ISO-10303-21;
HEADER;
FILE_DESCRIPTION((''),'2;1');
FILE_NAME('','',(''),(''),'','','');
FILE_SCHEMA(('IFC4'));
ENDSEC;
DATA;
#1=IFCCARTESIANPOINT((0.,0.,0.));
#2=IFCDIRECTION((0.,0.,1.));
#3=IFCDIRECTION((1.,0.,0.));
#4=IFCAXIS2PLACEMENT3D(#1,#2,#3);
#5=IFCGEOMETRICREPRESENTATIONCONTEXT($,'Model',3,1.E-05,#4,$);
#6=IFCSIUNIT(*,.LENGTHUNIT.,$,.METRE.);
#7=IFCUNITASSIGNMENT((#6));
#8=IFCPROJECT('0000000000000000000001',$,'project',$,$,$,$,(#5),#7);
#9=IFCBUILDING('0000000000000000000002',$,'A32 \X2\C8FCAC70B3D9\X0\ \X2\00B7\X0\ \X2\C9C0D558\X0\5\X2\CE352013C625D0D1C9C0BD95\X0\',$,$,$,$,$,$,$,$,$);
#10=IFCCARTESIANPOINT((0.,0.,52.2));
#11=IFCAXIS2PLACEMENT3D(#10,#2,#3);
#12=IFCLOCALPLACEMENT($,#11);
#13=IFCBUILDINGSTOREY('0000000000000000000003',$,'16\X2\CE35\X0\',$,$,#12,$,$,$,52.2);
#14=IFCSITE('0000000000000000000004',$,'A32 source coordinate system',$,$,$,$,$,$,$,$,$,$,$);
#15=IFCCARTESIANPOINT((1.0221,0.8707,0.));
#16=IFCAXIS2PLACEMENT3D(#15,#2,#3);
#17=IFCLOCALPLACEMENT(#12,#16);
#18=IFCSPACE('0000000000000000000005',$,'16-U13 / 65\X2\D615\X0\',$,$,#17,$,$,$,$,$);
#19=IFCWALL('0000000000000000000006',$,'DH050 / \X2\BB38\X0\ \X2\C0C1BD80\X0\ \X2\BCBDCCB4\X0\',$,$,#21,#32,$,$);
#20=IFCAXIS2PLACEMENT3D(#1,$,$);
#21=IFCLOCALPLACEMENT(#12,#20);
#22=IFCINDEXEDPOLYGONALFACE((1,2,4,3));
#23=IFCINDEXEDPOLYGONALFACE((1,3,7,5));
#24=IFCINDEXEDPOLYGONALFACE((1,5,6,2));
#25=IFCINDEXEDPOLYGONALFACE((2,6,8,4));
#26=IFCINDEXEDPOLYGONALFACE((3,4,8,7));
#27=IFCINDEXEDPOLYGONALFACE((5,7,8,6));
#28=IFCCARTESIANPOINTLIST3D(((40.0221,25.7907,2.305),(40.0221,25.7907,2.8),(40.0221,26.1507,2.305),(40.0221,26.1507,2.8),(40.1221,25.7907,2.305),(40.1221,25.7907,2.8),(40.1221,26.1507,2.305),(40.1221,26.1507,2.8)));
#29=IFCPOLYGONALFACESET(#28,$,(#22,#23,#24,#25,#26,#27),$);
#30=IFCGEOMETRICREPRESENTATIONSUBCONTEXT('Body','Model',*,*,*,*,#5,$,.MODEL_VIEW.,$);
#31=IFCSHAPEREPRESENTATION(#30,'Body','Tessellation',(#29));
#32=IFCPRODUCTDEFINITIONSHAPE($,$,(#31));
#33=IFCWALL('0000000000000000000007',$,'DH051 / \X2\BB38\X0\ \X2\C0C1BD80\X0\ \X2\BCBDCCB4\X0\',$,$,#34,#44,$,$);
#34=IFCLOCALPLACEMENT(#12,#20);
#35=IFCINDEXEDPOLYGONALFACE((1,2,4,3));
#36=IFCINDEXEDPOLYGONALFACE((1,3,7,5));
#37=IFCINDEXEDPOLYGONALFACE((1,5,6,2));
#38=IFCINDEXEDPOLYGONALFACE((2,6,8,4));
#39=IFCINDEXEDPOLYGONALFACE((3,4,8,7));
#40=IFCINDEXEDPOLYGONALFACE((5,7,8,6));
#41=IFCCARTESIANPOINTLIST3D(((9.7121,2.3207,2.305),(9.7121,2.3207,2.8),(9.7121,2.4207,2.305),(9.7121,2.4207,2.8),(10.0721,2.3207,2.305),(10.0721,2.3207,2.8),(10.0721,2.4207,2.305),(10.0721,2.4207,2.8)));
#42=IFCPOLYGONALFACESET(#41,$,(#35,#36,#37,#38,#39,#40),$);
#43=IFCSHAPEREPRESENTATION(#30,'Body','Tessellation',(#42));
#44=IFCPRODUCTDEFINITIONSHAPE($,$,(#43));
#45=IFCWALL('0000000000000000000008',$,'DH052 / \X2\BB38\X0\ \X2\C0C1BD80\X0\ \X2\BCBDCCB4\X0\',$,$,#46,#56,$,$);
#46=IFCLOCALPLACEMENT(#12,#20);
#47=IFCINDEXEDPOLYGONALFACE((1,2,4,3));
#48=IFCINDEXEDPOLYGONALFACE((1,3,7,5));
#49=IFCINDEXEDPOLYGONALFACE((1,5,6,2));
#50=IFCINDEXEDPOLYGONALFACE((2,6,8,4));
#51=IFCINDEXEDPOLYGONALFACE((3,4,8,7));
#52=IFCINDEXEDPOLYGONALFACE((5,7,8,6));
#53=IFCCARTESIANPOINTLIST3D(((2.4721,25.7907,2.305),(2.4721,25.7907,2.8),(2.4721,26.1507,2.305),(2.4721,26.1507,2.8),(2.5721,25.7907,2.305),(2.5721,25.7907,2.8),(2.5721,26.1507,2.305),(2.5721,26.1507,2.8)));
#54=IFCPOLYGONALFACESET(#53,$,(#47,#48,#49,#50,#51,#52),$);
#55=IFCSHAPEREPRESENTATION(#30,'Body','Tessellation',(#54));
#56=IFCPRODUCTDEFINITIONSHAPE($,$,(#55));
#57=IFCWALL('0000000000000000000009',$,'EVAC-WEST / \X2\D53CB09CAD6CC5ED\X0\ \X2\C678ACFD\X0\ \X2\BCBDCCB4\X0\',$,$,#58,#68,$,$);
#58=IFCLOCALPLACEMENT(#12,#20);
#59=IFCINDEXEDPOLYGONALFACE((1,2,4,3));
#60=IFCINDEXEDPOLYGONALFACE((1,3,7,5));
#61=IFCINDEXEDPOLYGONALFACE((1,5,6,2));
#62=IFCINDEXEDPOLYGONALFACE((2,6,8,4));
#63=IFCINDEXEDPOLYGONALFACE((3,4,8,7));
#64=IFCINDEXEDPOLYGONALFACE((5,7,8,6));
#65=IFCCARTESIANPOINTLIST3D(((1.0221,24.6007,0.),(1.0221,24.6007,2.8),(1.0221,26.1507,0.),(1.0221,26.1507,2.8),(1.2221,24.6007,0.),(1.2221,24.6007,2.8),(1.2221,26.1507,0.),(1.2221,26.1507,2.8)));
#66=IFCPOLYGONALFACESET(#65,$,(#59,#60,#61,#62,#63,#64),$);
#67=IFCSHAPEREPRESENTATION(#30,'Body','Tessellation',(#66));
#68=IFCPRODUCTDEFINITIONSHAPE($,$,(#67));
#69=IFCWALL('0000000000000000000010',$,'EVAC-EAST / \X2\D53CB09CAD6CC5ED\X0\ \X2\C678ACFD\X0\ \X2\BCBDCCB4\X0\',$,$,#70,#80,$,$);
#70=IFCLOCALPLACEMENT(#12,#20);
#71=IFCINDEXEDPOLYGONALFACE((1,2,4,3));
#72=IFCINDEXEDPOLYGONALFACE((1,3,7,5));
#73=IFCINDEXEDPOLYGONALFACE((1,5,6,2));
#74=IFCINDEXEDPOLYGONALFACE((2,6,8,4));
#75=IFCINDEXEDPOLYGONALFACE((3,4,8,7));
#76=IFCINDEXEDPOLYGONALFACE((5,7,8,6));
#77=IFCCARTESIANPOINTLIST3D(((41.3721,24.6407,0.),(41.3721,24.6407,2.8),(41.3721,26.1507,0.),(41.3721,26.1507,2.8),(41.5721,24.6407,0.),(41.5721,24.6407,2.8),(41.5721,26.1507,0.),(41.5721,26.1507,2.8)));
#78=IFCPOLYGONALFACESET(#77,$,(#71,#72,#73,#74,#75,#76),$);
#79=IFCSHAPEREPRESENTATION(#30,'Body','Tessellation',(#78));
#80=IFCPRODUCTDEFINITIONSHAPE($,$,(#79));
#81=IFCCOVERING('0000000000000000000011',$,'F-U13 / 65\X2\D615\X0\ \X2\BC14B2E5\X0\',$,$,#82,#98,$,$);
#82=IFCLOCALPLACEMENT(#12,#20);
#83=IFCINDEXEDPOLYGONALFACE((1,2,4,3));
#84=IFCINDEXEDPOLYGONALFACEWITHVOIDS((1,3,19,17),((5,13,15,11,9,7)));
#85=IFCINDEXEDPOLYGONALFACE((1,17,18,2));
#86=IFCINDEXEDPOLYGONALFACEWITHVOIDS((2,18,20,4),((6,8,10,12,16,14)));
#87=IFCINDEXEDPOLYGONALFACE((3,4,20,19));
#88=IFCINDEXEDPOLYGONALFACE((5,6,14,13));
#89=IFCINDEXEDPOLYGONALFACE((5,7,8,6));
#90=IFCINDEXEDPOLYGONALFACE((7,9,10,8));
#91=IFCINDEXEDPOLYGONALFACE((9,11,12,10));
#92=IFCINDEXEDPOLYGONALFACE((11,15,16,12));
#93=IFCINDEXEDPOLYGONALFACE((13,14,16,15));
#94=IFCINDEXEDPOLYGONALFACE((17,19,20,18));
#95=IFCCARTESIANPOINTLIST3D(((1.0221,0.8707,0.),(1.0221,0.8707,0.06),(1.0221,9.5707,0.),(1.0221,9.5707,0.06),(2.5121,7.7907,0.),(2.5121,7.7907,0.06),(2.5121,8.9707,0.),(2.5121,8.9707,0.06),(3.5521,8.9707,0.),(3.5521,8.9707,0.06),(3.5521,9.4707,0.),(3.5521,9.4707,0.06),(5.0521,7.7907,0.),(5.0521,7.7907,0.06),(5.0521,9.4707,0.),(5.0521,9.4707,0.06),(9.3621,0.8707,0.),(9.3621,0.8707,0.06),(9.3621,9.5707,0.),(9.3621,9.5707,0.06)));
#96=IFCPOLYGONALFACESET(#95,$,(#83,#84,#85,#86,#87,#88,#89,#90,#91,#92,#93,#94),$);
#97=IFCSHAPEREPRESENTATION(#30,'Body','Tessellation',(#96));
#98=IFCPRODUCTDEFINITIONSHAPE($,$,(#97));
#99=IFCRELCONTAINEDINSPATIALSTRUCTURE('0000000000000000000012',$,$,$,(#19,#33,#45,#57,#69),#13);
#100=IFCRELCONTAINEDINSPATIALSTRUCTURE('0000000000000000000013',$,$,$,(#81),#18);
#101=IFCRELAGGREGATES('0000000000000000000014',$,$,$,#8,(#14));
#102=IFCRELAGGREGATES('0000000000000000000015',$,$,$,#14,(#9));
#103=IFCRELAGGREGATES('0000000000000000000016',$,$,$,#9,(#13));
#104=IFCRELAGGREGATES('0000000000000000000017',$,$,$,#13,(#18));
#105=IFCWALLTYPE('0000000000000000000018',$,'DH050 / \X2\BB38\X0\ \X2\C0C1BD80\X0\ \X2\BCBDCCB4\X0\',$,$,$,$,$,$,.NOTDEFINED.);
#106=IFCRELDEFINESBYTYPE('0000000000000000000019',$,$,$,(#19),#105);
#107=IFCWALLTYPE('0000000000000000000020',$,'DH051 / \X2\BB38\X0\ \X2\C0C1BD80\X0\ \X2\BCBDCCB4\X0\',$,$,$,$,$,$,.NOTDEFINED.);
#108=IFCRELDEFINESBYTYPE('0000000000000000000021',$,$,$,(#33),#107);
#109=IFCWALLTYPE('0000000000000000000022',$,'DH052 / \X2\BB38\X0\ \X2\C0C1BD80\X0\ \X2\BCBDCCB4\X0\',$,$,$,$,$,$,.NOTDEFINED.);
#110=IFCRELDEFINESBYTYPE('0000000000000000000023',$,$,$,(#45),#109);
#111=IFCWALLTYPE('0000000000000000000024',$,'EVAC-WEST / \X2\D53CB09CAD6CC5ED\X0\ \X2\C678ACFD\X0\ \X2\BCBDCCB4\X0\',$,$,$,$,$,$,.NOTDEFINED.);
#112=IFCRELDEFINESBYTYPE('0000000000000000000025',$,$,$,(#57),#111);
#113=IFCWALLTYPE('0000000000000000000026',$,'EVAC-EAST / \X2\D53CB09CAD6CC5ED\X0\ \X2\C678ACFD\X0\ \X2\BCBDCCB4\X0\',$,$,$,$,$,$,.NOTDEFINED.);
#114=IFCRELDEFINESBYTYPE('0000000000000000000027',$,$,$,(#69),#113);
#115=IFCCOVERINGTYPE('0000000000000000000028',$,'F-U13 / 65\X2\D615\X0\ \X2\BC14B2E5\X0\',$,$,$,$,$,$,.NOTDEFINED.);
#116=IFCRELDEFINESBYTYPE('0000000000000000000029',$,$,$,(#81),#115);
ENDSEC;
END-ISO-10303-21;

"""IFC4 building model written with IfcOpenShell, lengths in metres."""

from ifc_helpers import new_model, si_unit, frame, origin, origin_with_axes, place, context, subcontext, project, spatial, polyline, outline, extrude, source, transform, mapped, type_object, type_shapes, element, save


model = new_model("IFC4")

# Units and contexts
model_context = context("Model", 3, precision=1e-05, world=origin_with_axes())
body_context = subcontext(model_context, "Body", "Model", "MODEL_VIEW")
ifc_project = project(units=[si_unit("LENGTHUNIT", "METRE")], contexts=[model_context])

# Site, building, storey
site = spatial("IfcSite", under=ifc_project, Name="A32 source coordinate system")
building = spatial("IfcBuilding", under=site, Name="A32 주거동 · 지하5층–옥탑지붕")
storey_placement = place(None, frame((0.0, 0.0, 52.2), z_axis=(0.0, 0.0, 1.0), x_axis=(1.0, 0.0, 0.0)))
storey = spatial("IfcBuildingStorey", under=building, at=storey_placement, Name="16층", Elevation=52.2)

# Walls
wall_type_1 = type_object("IfcWallType", Name="DH050 / 문 상부 벽체", PredefinedType="NOTDEFINED")
shared_shape_1 = source(origin(), body_context, "Body", "SweptSolid", [
    extrude(outline(polyline([(40.0221, 25.7907), (40.0221, 26.1507), (40.1221, 26.1507), (40.1221, 25.7907), (40.0221, 25.7907)])), frame((0.0, 0.0, 2.305)), (0.0, 0.0, 1.0), 0.495),
])
type_shapes(wall_type_1, [shared_shape_1])
wall_1_placement = place(storey_placement, origin_with_axes())
element("IfcWall", 1, at=wall_1_placement, inside=storey, type_object=wall_type_1, Name="DH050 / 문 상부 벽체", context=body_context, shape_type="MappedRepresentation", body=[
    mapped(shared_shape_1, transform((0.0, 0.0, 0.0), scale=1.0)),
])
wall_type_2 = type_object("IfcWallType", Name="DH051 / 문 상부 벽체", PredefinedType="NOTDEFINED")
shared_shape_2 = source(origin(), body_context, "Body", "SweptSolid", [
    extrude(outline(polyline([(10.0721, 2.3207), (9.7121, 2.3207), (9.7121, 2.4207), (10.0721, 2.4207), (10.0721, 2.3207)])), frame((0.0, 0.0, 2.305)), (0.0, 0.0, 1.0), 0.495),
])
type_shapes(wall_type_2, [shared_shape_2])
wall_2_placement = place(storey_placement, origin_with_axes())
element("IfcWall", 2, at=wall_2_placement, inside=storey, type_object=wall_type_2, Name="DH051 / 문 상부 벽체", context=body_context, shape_type="MappedRepresentation", body=[
    mapped(shared_shape_2, transform((0.0, 0.0, 0.0), scale=1.0)),
])
wall_type_3 = type_object("IfcWallType", Name="DH052 / 문 상부 벽체", PredefinedType="NOTDEFINED")
shared_shape_3 = source(origin(), body_context, "Body", "SweptSolid", [
    extrude(outline(polyline([(2.5721, 25.7907), (2.4721, 25.7907), (2.4721, 26.1507), (2.5721, 26.1507), (2.5721, 25.7907)])), frame((0.0, 0.0, 2.305)), (0.0, 0.0, 1.0), 0.495),
])
type_shapes(wall_type_3, [shared_shape_3])
wall_3_placement = place(storey_placement, origin_with_axes())
element("IfcWall", 3, at=wall_3_placement, inside=storey, type_object=wall_type_3, Name="DH052 / 문 상부 벽체", context=body_context, shape_type="MappedRepresentation", body=[
    mapped(shared_shape_3, transform((0.0, 0.0, 0.0), scale=1.0)),
])
wall_type_4 = type_object("IfcWallType", Name="EVAC-WEST / 피난구역 외곽 벽체", PredefinedType="NOTDEFINED")
shared_shape_4 = source(origin(), body_context, "Body", "SweptSolid", [
    extrude(outline(polyline([(1.2221, 24.6007), (1.0221, 24.6007), (1.0221, 26.1507), (1.2221, 26.1507), (1.2221, 24.6007)])), origin(), (0.0, 0.0, 1.0), 2.8),
])
type_shapes(wall_type_4, [shared_shape_4])
wall_4_placement = place(storey_placement, origin_with_axes())
element("IfcWall", 4, at=wall_4_placement, inside=storey, type_object=wall_type_4, Name="EVAC-WEST / 피난구역 외곽 벽체", context=body_context, shape_type="MappedRepresentation", body=[
    mapped(shared_shape_4, transform((0.0, 0.0, 0.0), scale=1.0)),
])
wall_type_5 = type_object("IfcWallType", Name="EVAC-EAST / 피난구역 외곽 벽체", PredefinedType="NOTDEFINED")
shared_shape_5 = source(origin(), body_context, "Body", "SweptSolid", [
    extrude(outline(polyline([(41.5721, 26.1507), (41.5721, 24.6407), (41.3721, 24.6407), (41.3721, 26.1507), (41.5721, 26.1507)])), origin(), (0.0, 0.0, 1.0), 2.8),
])
type_shapes(wall_type_5, [shared_shape_5])
wall_5_placement = place(storey_placement, origin_with_axes())
element("IfcWall", 5, at=wall_5_placement, inside=storey, type_object=wall_type_5, Name="EVAC-EAST / 피난구역 외곽 벽체", context=body_context, shape_type="MappedRepresentation", body=[
    mapped(shared_shape_5, transform((0.0, 0.0, 0.0), scale=1.0)),
])

# Shared definitions
space_placement = place(storey_placement, frame((1.0221, 0.8707, 0.0), z_axis=(0.0, 0.0, 1.0), x_axis=(1.0, 0.0, 0.0)))
space = spatial("IfcSpace", under=storey, at=space_placement, Name="16-U13 / 65형")

# Covering
covering_type_1 = type_object("IfcCoveringType", Name="F-U13 / 65형 바닥", PredefinedType="NOTDEFINED")
shared_shape_6 = source(origin(), body_context, "Body", "SweptSolid", [
    extrude(outline(polyline([(0.0, 0.0), (0.0, 8.7), (8.34, 8.7), (8.34, 0.0), (0.0, 0.0)]), holes=[polyline([(2.53, 8.1), (1.49, 8.1), (1.49, 6.92), (4.03, 6.92), (4.03, 8.6), (2.53, 8.6), (2.53, 8.1)])]), origin(), (0.0, 0.0, 1.0), 0.06),
])
type_shapes(covering_type_1, [shared_shape_6])
covering_1_placement = place(space_placement, origin_with_axes())
element("IfcCovering", 6, at=covering_1_placement, inside=space, type_object=covering_type_1, Name="F-U13 / 65형 바닥", context=body_context, shape_type="MappedRepresentation", body=[
    mapped(shared_shape_6, transform((0.0, 0.0, 0.0), scale=1.0)),
])

save(model, "model.ifc")
